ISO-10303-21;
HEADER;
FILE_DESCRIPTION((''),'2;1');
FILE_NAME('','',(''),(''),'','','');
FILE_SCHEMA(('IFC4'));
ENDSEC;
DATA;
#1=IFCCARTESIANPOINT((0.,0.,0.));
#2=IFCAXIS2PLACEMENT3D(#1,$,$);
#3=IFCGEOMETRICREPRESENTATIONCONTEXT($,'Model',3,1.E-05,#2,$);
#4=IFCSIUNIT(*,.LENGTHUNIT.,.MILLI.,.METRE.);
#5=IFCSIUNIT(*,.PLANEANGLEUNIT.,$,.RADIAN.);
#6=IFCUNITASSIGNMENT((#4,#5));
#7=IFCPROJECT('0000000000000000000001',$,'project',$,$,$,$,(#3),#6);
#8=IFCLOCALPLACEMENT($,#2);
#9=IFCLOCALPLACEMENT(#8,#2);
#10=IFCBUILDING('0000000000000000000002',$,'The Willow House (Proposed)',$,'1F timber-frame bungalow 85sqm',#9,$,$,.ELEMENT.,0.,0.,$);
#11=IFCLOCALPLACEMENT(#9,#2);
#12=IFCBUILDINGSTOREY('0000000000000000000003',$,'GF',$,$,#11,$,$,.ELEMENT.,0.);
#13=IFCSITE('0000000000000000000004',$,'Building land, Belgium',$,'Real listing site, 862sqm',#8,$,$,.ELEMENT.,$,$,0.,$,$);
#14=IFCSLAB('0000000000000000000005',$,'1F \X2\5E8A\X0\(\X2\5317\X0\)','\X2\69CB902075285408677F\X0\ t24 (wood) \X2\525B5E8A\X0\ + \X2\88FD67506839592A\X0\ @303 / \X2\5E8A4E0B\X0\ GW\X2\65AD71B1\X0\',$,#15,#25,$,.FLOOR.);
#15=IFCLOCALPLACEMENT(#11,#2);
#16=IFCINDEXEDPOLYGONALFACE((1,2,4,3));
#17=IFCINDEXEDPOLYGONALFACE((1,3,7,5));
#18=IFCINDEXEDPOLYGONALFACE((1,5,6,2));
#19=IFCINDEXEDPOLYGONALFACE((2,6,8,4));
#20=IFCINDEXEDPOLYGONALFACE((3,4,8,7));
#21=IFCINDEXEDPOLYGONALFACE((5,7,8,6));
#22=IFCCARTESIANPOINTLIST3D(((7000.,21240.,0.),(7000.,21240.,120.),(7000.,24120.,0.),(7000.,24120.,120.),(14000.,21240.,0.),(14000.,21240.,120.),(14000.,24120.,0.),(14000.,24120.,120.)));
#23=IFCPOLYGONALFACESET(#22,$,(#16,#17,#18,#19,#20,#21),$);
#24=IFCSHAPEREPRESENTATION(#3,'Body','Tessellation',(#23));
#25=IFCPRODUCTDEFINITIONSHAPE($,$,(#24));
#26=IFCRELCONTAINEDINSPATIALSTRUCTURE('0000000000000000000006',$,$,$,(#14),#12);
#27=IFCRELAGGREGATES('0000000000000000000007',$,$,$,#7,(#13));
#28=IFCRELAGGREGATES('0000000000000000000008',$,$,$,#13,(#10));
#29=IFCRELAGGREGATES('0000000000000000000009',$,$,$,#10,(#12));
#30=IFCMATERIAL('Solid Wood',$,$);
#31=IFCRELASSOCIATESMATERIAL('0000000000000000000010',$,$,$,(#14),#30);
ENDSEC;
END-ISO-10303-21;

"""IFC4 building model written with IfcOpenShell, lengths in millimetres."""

from ifc_helpers import new_model, si_unit, frame, frame_2d, origin, place, context, project, spatial, rectangle, extrude, material, element, save


model = new_model("IFC4")

# Units and contexts
model_context = context("Model", 3, precision=1e-05, world=origin())
ifc_project = project(units=[si_unit("LENGTHUNIT", "METRE", prefix="MILLI"), si_unit("PLANEANGLEUNIT", "RADIAN")], contexts=[model_context])

# Site, building, storey
site_placement = place(None, origin())
site = spatial("IfcSite", under=ifc_project, at=site_placement, Name="Building land, Belgium", ObjectType="Real listing site, 862sqm", CompositionType="ELEMENT", RefElevation=0.0)
building_placement = place(site_placement, origin())
building = spatial("IfcBuilding", under=site, at=building_placement, Name="The Willow House (Proposed)", ObjectType="1F timber-frame bungalow 85sqm", CompositionType="ELEMENT", ElevationOfRefHeight=0.0, ElevationOfTerrain=0.0)
storey_placement = place(building_placement, origin())
storey = spatial("IfcBuildingStorey", under=building, at=storey_placement, Name="GF", CompositionType="ELEMENT", Elevation=0.0)

# Slab
ifc_material_1 = material(Name="Solid Wood")
slab_1_placement = place(storey_placement, frame((3500.0, 10620.0, 0.0)))
element("IfcSlab", 1, at=slab_1_placement, inside=storey, material=ifc_material_1, Name="1F 床(北)", Description="構造用合板 t24 (wood) 剛床 + 製材根太 @303 / 床下 GW断熱", PredefinedType="FLOOR", context=model_context, shape_type="SweptSolid", body=[
    extrude(rectangle(XDim=7000.0, YDim=2880.0, at=frame_2d((3500.0, 1440.0))), frame((3500.0, 10620.0, 0.0)), (0.0, 0.0, 1.0), 120.0),
])

save(model, "model.ifc")
